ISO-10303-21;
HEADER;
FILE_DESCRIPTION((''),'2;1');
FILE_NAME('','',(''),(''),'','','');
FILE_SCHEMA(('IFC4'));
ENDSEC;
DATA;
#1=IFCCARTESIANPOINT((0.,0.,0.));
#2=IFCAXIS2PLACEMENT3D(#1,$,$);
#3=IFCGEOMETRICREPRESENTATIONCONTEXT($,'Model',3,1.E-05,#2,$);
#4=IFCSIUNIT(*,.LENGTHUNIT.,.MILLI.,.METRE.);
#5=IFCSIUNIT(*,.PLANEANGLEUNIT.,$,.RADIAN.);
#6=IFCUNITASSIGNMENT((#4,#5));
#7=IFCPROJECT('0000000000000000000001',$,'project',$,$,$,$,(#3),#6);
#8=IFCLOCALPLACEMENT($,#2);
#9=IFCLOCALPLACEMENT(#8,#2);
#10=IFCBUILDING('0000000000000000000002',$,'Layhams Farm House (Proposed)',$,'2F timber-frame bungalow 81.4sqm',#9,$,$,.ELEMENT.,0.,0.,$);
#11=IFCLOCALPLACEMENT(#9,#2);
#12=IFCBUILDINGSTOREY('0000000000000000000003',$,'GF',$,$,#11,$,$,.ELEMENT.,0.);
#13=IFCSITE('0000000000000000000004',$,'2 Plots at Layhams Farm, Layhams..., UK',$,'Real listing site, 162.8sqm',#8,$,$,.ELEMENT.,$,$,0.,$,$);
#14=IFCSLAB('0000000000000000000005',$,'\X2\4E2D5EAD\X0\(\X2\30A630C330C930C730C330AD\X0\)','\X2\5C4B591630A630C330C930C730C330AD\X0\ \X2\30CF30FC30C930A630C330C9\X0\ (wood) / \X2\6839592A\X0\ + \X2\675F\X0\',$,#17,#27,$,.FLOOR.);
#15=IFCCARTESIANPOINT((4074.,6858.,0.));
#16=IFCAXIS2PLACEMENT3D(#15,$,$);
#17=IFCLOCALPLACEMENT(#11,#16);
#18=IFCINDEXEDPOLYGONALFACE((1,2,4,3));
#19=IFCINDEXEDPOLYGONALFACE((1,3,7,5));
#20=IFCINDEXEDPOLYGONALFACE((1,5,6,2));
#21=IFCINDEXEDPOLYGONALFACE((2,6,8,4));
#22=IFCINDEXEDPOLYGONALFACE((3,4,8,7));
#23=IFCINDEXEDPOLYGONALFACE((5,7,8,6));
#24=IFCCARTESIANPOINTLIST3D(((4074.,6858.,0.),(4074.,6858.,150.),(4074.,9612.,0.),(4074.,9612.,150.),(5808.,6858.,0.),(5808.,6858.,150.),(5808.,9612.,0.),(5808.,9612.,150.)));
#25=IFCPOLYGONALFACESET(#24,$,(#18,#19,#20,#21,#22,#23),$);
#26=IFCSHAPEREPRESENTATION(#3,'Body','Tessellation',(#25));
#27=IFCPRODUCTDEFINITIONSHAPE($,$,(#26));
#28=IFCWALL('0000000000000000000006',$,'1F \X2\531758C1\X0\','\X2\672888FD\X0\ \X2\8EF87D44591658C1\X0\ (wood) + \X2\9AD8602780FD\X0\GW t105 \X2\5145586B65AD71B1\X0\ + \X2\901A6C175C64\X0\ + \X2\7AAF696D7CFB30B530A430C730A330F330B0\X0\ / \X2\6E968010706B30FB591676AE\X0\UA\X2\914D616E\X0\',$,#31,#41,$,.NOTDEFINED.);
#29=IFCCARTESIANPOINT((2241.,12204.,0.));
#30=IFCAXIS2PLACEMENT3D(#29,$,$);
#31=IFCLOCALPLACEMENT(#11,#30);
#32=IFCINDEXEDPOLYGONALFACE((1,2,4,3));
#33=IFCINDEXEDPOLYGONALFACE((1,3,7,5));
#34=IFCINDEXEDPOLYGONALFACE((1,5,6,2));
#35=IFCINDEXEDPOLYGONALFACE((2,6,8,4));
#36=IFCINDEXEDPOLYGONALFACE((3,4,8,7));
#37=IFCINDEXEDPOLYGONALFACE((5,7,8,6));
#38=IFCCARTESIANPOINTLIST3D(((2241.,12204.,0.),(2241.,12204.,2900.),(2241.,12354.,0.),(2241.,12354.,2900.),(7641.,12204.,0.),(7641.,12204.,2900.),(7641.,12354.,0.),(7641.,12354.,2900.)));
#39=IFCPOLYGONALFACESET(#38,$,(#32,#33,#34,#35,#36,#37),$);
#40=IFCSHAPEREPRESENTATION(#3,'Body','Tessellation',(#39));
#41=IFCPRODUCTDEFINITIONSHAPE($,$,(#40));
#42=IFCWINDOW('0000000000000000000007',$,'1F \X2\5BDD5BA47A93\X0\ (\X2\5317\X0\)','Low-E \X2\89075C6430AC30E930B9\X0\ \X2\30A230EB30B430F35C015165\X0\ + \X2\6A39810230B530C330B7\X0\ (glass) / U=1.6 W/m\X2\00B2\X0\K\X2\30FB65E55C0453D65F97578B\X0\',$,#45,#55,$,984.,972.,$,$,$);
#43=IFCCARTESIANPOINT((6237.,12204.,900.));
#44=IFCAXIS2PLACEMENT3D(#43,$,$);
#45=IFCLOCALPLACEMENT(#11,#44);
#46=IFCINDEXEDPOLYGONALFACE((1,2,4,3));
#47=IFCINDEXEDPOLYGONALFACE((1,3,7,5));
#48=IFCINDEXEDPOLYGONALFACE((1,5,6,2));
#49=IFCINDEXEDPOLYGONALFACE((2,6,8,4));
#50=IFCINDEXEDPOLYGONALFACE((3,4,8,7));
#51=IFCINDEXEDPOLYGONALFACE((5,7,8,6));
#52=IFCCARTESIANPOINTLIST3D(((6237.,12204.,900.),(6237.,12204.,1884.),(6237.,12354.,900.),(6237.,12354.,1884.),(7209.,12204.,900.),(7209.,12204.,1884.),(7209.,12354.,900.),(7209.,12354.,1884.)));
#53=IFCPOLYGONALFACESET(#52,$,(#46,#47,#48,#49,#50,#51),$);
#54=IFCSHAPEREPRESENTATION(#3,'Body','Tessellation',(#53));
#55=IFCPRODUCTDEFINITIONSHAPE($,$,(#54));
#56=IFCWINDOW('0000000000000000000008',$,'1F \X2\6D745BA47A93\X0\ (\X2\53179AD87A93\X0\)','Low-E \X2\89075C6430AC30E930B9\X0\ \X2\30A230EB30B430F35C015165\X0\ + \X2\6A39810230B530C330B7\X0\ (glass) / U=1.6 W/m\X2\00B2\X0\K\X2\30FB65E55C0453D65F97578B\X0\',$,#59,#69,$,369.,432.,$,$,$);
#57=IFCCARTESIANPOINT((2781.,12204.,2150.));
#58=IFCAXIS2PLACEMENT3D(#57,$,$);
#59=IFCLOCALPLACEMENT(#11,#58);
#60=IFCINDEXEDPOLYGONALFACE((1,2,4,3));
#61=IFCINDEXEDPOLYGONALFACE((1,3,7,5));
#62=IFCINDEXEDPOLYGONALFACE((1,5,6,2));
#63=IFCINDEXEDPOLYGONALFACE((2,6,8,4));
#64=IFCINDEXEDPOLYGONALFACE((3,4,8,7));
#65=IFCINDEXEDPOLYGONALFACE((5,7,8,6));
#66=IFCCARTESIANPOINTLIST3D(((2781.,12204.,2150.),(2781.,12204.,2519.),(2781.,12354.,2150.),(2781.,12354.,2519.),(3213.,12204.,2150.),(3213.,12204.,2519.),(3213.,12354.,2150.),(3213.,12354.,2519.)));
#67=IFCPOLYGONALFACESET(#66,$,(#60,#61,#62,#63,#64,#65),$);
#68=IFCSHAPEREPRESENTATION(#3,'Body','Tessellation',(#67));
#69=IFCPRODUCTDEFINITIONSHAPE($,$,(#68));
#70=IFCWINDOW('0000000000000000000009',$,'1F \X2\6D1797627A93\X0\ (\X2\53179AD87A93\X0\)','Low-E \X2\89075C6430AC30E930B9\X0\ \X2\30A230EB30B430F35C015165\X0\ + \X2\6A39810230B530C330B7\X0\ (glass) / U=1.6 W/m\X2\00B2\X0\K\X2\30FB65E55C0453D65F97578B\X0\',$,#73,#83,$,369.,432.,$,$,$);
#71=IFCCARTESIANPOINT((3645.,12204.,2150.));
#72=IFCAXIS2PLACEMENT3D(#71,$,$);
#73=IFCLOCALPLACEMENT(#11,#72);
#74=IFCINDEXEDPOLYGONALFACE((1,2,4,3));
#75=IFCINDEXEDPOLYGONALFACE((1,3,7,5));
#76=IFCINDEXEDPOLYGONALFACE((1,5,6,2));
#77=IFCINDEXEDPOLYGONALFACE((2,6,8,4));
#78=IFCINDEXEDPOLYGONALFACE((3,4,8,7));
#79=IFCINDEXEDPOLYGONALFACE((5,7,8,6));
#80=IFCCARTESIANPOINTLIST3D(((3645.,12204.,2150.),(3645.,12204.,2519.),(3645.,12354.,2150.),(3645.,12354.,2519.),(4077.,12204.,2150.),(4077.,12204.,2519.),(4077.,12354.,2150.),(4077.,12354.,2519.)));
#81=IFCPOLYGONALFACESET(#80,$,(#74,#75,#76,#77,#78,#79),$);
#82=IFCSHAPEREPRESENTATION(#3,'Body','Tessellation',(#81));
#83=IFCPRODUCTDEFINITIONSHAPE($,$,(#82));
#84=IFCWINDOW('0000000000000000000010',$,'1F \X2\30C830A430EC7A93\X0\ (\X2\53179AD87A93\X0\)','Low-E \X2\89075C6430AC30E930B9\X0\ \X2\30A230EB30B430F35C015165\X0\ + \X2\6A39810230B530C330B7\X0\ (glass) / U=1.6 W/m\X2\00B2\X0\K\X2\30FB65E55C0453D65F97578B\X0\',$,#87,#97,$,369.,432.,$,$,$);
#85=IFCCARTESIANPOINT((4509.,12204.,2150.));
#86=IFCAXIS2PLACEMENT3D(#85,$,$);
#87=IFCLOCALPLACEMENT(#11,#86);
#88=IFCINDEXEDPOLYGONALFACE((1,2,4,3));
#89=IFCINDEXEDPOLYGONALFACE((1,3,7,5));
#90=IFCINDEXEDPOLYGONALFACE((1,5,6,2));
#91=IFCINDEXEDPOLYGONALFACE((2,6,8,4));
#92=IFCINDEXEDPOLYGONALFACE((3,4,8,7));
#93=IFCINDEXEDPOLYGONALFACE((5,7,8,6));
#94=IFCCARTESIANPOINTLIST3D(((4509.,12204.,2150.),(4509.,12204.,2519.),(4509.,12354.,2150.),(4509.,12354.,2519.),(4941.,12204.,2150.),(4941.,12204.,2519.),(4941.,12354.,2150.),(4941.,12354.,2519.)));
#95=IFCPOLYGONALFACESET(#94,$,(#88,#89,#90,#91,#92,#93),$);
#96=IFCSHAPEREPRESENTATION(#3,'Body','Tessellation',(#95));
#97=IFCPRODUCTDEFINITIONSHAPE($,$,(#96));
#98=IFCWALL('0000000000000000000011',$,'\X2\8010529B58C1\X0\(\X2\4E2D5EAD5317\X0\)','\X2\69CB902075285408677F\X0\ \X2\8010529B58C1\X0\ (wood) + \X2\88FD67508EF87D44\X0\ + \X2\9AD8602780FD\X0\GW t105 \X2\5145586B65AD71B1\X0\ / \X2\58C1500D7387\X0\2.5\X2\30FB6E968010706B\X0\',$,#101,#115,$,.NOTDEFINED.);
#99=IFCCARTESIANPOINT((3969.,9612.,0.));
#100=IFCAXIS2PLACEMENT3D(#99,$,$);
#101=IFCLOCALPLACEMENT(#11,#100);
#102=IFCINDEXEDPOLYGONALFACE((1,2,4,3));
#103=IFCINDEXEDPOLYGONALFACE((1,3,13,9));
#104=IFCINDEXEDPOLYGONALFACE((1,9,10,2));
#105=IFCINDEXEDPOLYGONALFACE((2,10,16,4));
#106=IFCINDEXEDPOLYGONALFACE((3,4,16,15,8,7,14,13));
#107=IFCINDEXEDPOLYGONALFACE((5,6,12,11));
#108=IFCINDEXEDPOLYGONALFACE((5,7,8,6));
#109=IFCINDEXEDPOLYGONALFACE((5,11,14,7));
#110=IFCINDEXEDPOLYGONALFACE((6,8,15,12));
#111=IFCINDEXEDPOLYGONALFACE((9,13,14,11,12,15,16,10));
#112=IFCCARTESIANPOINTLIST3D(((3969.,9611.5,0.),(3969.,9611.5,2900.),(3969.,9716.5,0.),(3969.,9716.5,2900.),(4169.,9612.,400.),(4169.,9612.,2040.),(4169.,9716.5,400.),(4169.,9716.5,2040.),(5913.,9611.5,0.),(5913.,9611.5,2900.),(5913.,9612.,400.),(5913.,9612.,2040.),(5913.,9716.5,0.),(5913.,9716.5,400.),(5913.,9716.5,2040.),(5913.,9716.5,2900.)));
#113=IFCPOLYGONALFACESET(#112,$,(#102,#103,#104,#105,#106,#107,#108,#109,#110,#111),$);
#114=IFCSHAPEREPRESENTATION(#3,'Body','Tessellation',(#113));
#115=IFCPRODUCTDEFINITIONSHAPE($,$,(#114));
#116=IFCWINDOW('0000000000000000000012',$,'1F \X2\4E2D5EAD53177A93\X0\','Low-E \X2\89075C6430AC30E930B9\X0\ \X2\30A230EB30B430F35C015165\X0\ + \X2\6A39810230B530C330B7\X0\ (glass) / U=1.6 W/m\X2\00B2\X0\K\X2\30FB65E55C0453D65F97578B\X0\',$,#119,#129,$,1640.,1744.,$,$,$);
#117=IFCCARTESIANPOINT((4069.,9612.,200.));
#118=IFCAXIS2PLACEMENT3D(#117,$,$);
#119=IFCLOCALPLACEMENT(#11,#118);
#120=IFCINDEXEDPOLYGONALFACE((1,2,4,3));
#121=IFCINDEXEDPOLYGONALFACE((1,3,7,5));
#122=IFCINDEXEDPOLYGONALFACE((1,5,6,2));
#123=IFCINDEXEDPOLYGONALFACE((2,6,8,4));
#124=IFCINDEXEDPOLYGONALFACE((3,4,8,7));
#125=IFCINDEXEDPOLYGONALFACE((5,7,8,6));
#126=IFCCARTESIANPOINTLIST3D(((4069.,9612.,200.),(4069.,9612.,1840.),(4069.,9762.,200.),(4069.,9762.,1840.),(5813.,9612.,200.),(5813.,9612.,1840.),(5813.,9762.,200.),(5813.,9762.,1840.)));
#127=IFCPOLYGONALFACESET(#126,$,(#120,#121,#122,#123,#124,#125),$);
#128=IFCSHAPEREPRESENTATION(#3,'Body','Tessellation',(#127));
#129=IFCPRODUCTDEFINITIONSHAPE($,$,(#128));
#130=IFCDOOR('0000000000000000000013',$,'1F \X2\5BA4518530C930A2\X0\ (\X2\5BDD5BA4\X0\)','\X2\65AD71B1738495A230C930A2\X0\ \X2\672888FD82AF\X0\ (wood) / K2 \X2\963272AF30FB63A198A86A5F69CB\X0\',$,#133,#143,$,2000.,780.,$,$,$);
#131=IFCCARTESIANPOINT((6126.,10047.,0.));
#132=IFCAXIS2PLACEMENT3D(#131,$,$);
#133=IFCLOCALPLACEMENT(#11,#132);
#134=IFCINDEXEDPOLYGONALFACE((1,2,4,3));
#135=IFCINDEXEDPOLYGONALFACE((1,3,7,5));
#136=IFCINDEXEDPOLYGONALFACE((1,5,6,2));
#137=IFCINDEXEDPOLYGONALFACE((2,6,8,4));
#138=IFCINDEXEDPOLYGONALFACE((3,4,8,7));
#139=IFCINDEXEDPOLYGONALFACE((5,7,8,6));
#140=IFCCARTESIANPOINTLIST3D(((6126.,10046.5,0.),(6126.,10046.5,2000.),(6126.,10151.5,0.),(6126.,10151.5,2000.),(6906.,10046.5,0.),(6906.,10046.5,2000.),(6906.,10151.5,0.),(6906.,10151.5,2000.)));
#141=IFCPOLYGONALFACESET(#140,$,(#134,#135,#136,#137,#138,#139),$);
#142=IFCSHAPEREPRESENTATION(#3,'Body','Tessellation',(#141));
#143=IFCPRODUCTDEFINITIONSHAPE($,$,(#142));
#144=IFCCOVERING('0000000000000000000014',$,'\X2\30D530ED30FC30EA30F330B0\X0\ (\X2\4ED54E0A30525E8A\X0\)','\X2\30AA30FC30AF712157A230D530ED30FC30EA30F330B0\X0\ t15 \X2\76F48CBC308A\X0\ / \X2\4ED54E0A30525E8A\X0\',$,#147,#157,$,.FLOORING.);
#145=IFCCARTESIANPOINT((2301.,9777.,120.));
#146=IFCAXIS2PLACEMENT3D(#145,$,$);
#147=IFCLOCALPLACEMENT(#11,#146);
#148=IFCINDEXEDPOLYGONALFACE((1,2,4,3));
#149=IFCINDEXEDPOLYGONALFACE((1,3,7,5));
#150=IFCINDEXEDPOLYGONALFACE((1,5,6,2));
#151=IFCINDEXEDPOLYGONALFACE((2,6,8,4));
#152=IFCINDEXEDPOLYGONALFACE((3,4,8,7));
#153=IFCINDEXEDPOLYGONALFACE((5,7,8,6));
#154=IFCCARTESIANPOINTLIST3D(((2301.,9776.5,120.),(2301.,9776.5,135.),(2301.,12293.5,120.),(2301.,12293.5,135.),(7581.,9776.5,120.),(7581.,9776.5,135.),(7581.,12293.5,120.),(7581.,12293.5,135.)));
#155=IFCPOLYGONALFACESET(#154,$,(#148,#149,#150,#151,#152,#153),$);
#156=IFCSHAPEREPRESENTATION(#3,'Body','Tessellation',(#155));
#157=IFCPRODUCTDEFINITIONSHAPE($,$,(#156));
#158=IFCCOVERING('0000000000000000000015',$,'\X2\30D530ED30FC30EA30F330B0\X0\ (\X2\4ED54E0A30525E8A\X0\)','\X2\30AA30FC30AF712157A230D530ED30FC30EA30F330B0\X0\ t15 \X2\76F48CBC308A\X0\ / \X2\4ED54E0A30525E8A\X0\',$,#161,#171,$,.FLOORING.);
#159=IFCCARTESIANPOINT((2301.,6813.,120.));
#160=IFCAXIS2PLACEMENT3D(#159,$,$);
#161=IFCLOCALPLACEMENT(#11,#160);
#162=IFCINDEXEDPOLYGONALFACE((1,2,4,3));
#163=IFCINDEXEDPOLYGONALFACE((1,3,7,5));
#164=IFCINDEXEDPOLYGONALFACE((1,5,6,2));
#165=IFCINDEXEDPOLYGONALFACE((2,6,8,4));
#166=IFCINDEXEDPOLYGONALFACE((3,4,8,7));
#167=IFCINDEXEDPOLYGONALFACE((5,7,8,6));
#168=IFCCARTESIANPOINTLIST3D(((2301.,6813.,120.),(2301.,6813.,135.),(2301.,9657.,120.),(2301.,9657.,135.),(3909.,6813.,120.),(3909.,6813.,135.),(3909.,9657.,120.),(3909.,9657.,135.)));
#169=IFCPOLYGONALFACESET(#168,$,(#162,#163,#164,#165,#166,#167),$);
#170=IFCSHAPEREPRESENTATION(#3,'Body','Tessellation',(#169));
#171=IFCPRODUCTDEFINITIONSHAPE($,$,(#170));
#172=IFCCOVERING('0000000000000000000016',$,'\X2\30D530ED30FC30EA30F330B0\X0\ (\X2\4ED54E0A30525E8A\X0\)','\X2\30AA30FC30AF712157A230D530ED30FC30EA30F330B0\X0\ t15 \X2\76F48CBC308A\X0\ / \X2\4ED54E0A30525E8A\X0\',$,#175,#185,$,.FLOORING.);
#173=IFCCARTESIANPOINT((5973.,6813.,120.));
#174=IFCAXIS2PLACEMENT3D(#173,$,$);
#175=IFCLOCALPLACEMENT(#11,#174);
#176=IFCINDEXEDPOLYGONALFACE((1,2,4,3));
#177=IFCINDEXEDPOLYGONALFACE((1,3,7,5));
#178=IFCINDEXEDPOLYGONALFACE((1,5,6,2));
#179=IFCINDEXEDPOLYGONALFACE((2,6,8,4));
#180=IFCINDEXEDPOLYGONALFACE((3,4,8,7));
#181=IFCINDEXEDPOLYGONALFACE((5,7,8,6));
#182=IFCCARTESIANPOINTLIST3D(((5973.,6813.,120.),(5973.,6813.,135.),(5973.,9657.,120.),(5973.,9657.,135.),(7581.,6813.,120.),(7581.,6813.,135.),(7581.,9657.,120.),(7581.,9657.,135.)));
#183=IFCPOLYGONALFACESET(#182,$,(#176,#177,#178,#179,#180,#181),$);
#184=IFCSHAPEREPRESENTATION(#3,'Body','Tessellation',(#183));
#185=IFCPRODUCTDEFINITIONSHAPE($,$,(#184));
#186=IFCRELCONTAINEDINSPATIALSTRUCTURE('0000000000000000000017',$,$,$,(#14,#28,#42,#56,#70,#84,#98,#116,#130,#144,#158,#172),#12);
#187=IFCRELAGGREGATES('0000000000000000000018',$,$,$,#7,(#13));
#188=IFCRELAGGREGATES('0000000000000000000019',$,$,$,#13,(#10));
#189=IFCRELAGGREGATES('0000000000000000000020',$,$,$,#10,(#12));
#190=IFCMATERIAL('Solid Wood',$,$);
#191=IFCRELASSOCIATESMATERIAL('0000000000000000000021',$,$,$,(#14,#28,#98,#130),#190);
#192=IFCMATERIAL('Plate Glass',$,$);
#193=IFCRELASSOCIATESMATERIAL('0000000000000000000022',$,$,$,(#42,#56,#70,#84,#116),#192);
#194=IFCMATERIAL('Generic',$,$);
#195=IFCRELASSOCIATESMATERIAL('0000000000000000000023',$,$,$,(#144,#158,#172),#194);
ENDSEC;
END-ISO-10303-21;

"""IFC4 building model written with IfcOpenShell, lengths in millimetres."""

from ifc_helpers import new_model, si_unit, frame, frame_2d, origin, place, context, project, spatial, rectangle, extrude, material, element, fill, save


model = new_model("IFC4")

# Units and contexts
model_context = context("Model", 3, precision=1e-05, world=origin())
ifc_project = project(units=[si_unit("LENGTHUNIT", "METRE", prefix="MILLI"), si_unit("PLANEANGLEUNIT", "RADIAN")], contexts=[model_context])

# Site, building, storey
site_placement = place(None, origin())
site = spatial("IfcSite", under=ifc_project, at=site_placement, Name="2 Plots at Layhams Farm, Layhams..., UK", ObjectType="Real listing site, 162.8sqm", CompositionType="ELEMENT", RefElevation=0.0)
building_placement = place(site_placement, origin())
building = spatial("IfcBuilding", under=site, at=building_placement, Name="Layhams Farm House (Proposed)", ObjectType="2F timber-frame bungalow 81.4sqm", CompositionType="ELEMENT", ElevationOfRefHeight=0.0, ElevationOfTerrain=0.0)
storey_placement = place(building_placement, origin())
storey = spatial("IfcBuildingStorey", under=building, at=storey_placement, Name="GF", CompositionType="ELEMENT", Elevation=0.0)

# Slab
ifc_material_1 = material(Name="Solid Wood")
slab_1_placement = place(storey_placement, frame((4074.0, 6858.0, 0.0)))
element("IfcSlab", 1, at=slab_1_placement, inside=storey, material=ifc_material_1, Name="中庭(ウッドデッキ)", Description="屋外ウッドデッキ ハードウッド (wood) / 根太 + 束", PredefinedType="FLOOR", context=model_context, shape_type="SweptSolid", body=[
    extrude(rectangle(XDim=1734.0, YDim=2754.0, at=frame_2d((867.0, 1377.0))), frame((4074.0, 6858.0, 0.0)), (0.0, 0.0, 1.0), 150.0),
])

# Wall, openings, windows
wall_1_placement = place(storey_placement, frame((2241.0, 12204.0, 0.0)))
wall_1 = element("IfcWall", 2, at=wall_1_placement, inside=storey, material=ifc_material_1, Name="1F 北壁", Description="木製 軸組外壁 (wood) + 高性能GW t105 充填断熱 + 通気層 + 窯業系サイディング / 準耐火・外皮UA配慮", PredefinedType="NOTDEFINED", context=model_context, shape_type="SweptSolid", body=[
    extrude(rectangle(XDim=5400.0, YDim=150.0, at=frame_2d((2700.0, 75.0))), frame((2241.0, 12204.0, 0.0)), (0.0, 0.0, 1.0), 2900.0),
])
opening_1_placement = place(storey_placement, frame((6237.0, 12204.0, 900.0)))
opening_1 = element("IfcOpeningElement", 3, at=opening_1_placement, cuts=wall_1, PredefinedType="NOTDEFINED", context=model_context, shape_type="SweptSolid", body=[
    extrude(rectangle(XDim=972.0, YDim=150.0, at=frame_2d((486.0, 75.0))), frame((6237.0, 12204.0, 900.0)), (0.0, 0.0, 1.0), 984.0),
])
opening_2_placement = place(storey_placement, frame((2781.0, 12204.0, 2150.0)))
opening_2 = element("IfcOpeningElement", 4, at=opening_2_placement, cuts=wall_1, PredefinedType="NOTDEFINED", context=model_context, shape_type="SweptSolid", body=[
    extrude(rectangle(XDim=432.0, YDim=150.0, at=frame_2d((216.0, 75.0))), frame((2781.0, 12204.0, 2150.0)), (0.0, 0.0, 1.0), 369.0),
])
opening_3_placement = place(storey_placement, frame((3645.0, 12204.0, 2150.0)))
opening_3 = element("IfcOpeningElement", 5, at=opening_3_placement, cuts=wall_1, PredefinedType="NOTDEFINED", context=model_context, shape_type="SweptSolid", body=[
    extrude(rectangle(XDim=432.0, YDim=150.0, at=frame_2d((216.0, 75.0))), frame((3645.0, 12204.0, 2150.0)), (0.0, 0.0, 1.0), 369.0),
])
opening_4_placement = place(storey_placement, frame((4509.0, 12204.0, 2150.0)))
opening_4 = element("IfcOpeningElement", 6, at=opening_4_placement, cuts=wall_1, PredefinedType="NOTDEFINED", context=model_context, shape_type="SweptSolid", body=[
    extrude(rectangle(XDim=432.0, YDim=150.0, at=frame_2d((216.0, 75.0))), frame((4509.0, 12204.0, 2150.0)), (0.0, 0.0, 1.0), 369.0),
])
ifc_material_2 = material(Name="Plate Glass")
window_1_placement = place(storey_placement, frame((6237.0, 12204.0, 900.0)))
window_1 = element("IfcWindow", 7, at=window_1_placement, inside=storey, material=ifc_material_2, Name="1F 寝室窓 (北)", Description="Low-E 複層ガラス アルゴン封入 + 樹脂サッシ (glass) / U=1.6 W/m²K・日射取得型", OverallHeight=984.0, OverallWidth=972.0, context=model_context, shape_type="SweptSolid", body=[
    extrude(rectangle(XDim=972.0, YDim=150.0, at=frame_2d((486.0, 75.0))), frame((6237.0, 12204.0, 900.0)), (0.0, 0.0, 1.0), 984.0),
])
fill(opening_1, window_1)
window_2_placement = place(storey_placement, frame((2781.0, 12204.0, 2150.0)))
window_2 = element("IfcWindow", 8, at=window_2_placement, inside=storey, material=ifc_material_2, Name="1F 浴室窓 (北高窓)", Description="Low-E 複層ガラス アルゴン封入 + 樹脂サッシ (glass) / U=1.6 W/m²K・日射取得型", OverallHeight=369.0, OverallWidth=432.0, context=model_context, shape_type="SweptSolid", body=[
    extrude(rectangle(XDim=432.0, YDim=150.0, at=frame_2d((216.0, 75.0))), frame((2781.0, 12204.0, 2150.0)), (0.0, 0.0, 1.0), 369.0),
])
fill(opening_2, window_2)
window_3_placement = place(storey_placement, frame((3645.0, 12204.0, 2150.0)))
window_3 = element("IfcWindow", 9, at=window_3_placement, inside=storey, material=ifc_material_2, Name="1F 洗面窓 (北高窓)", Description="Low-E 複層ガラス アルゴン封入 + 樹脂サッシ (glass) / U=1.6 W/m²K・日射取得型", OverallHeight=369.0, OverallWidth=432.0, context=model_context, shape_type="SweptSolid", body=[
    extrude(rectangle(XDim=432.0, YDim=150.0, at=frame_2d((216.0, 75.0))), frame((3645.0, 12204.0, 2150.0)), (0.0, 0.0, 1.0), 369.0),
])
fill(opening_3, window_3)
window_4_placement = place(storey_placement, frame((4509.0, 12204.0, 2150.0)))
window_4 = element("IfcWindow", 10, at=window_4_placement, inside=storey, material=ifc_material_2, Name="1F トイレ窓 (北高窓)", Description="Low-E 複層ガラス アルゴン封入 + 樹脂サッシ (glass) / U=1.6 W/m²K・日射取得型", OverallHeight=369.0, OverallWidth=432.0, context=model_context, shape_type="SweptSolid", body=[
    extrude(rectangle(XDim=432.0, YDim=150.0, at=frame_2d((216.0, 75.0))), frame((4509.0, 12204.0, 2150.0)), (0.0, 0.0, 1.0), 369.0),
])
fill(opening_4, window_4)

# Wall, opening, window
wall_2_placement = place(storey_placement, frame((3969.0, 9612.0, 0.0)))
wall_2 = element("IfcWall", 11, at=wall_2_placement, inside=storey, material=ifc_material_1, Name="耐力壁(中庭北)", Description="構造用合板 耐力壁 (wood) + 製材軸組 + 高性能GW t105 充填断熱 / 壁倍率2.5・準耐火", PredefinedType="NOTDEFINED", context=model_context, shape_type="SweptSolid", body=[
    extrude(rectangle(XDim=1944.0, YDim=105.0, at=frame_2d((972.0, 52.0))), frame((3969.0, 9612.0, 0.0)), (0.0, 0.0, 1.0), 2900.0),
])
opening_5_placement = place(storey_placement, frame((4069.0, 9612.0, 200.0)))
opening_5 = element("IfcOpeningElement", 12, at=opening_5_placement, cuts=wall_2, PredefinedType="NOTDEFINED", context=model_context, shape_type="SweptSolid", body=[
    extrude(rectangle(XDim=1744.0, YDim=150.0, at=frame_2d((872.0, 75.0))), frame((4069.0, 9612.0, 200.0)), (0.0, 0.0, 1.0), 1640.0),
])
window_5_placement = place(storey_placement, frame((4069.0, 9612.0, 200.0)))
window_5 = element("IfcWindow", 13, at=window_5_placement, inside=storey, material=ifc_material_2, Name="1F 中庭北窓", Description="Low-E 複層ガラス アルゴン封入 + 樹脂サッシ (glass) / U=1.6 W/m²K・日射取得型", OverallHeight=1640.0, OverallWidth=1744.0, context=model_context, shape_type="SweptSolid", body=[
    extrude(rectangle(XDim=1744.0, YDim=150.0, at=frame_2d((872.0, 75.0))), frame((4069.0, 9612.0, 200.0)), (0.0, 0.0, 1.0), 1640.0),
])
fill(opening_5, window_5)

# Door
door_1_placement = place(storey_placement, frame((6126.0, 10047.0, 0.0)))
element("IfcDoor", 14, at=door_1_placement, inside=storey, material=ifc_material_1, Name="1F 室内ドア (寝室)", Description="断熱玄関ドア 木製芯 (wood) / K2 防犯・採風機構", OverallHeight=2000.0, OverallWidth=780.0, context=model_context, shape_type="SweptSolid", body=[
    extrude(rectangle(XDim=780.0, YDim=105.0, at=frame_2d((390.0, 52.0))), frame((6126.0, 10047.0, 0.0)), (0.0, 0.0, 1.0), 2000.0),
])

# Coverings
ifc_material_3 = material(Name="Generic")
covering_1_placement = place(storey_placement, frame((2301.0, 9777.0, 120.0)))
element("IfcCovering", 15, at=covering_1_placement, inside=storey, material=ifc_material_3, Name="フローリング (仕上げ床)", Description="オーク無垢フローリング t15 直貼り / 仕上げ床", PredefinedType="FLOORING", context=model_context, shape_type="SweptSolid", body=[
    extrude(rectangle(XDim=5280.0, YDim=2517.0, at=frame_2d((2640.0, 1258.0))), frame((2301.0, 9777.0, 120.0)), (0.0, 0.0, 1.0), 15.0),
])
covering_2_placement = place(storey_placement, frame((2301.0, 6813.0, 120.0)))
element("IfcCovering", 16, at=covering_2_placement, inside=storey, material=ifc_material_3, Name="フローリング (仕上げ床)", Description="オーク無垢フローリング t15 直貼り / 仕上げ床", PredefinedType="FLOORING", context=model_context, shape_type="SweptSolid", body=[
    extrude(rectangle(XDim=1608.0, YDim=2844.0, at=frame_2d((804.0, 1422.0))), frame((2301.0, 6813.0, 120.0)), (0.0, 0.0, 1.0), 15.0),
])
covering_3_placement = place(storey_placement, frame((5973.0, 6813.0, 120.0)))
element("IfcCovering", 17, at=covering_3_placement, inside=storey, material=ifc_material_3, Name="フローリング (仕上げ床)", Description="オーク無垢フローリング t15 直貼り / 仕上げ床", PredefinedType="FLOORING", context=model_context, shape_type="SweptSolid", body=[
    extrude(rectangle(XDim=1608.0, YDim=2844.0, at=frame_2d((804.0, 1422.0))), frame((5973.0, 6813.0, 120.0)), (0.0, 0.0, 1.0), 15.0),
])

save(model, "model.ifc")
